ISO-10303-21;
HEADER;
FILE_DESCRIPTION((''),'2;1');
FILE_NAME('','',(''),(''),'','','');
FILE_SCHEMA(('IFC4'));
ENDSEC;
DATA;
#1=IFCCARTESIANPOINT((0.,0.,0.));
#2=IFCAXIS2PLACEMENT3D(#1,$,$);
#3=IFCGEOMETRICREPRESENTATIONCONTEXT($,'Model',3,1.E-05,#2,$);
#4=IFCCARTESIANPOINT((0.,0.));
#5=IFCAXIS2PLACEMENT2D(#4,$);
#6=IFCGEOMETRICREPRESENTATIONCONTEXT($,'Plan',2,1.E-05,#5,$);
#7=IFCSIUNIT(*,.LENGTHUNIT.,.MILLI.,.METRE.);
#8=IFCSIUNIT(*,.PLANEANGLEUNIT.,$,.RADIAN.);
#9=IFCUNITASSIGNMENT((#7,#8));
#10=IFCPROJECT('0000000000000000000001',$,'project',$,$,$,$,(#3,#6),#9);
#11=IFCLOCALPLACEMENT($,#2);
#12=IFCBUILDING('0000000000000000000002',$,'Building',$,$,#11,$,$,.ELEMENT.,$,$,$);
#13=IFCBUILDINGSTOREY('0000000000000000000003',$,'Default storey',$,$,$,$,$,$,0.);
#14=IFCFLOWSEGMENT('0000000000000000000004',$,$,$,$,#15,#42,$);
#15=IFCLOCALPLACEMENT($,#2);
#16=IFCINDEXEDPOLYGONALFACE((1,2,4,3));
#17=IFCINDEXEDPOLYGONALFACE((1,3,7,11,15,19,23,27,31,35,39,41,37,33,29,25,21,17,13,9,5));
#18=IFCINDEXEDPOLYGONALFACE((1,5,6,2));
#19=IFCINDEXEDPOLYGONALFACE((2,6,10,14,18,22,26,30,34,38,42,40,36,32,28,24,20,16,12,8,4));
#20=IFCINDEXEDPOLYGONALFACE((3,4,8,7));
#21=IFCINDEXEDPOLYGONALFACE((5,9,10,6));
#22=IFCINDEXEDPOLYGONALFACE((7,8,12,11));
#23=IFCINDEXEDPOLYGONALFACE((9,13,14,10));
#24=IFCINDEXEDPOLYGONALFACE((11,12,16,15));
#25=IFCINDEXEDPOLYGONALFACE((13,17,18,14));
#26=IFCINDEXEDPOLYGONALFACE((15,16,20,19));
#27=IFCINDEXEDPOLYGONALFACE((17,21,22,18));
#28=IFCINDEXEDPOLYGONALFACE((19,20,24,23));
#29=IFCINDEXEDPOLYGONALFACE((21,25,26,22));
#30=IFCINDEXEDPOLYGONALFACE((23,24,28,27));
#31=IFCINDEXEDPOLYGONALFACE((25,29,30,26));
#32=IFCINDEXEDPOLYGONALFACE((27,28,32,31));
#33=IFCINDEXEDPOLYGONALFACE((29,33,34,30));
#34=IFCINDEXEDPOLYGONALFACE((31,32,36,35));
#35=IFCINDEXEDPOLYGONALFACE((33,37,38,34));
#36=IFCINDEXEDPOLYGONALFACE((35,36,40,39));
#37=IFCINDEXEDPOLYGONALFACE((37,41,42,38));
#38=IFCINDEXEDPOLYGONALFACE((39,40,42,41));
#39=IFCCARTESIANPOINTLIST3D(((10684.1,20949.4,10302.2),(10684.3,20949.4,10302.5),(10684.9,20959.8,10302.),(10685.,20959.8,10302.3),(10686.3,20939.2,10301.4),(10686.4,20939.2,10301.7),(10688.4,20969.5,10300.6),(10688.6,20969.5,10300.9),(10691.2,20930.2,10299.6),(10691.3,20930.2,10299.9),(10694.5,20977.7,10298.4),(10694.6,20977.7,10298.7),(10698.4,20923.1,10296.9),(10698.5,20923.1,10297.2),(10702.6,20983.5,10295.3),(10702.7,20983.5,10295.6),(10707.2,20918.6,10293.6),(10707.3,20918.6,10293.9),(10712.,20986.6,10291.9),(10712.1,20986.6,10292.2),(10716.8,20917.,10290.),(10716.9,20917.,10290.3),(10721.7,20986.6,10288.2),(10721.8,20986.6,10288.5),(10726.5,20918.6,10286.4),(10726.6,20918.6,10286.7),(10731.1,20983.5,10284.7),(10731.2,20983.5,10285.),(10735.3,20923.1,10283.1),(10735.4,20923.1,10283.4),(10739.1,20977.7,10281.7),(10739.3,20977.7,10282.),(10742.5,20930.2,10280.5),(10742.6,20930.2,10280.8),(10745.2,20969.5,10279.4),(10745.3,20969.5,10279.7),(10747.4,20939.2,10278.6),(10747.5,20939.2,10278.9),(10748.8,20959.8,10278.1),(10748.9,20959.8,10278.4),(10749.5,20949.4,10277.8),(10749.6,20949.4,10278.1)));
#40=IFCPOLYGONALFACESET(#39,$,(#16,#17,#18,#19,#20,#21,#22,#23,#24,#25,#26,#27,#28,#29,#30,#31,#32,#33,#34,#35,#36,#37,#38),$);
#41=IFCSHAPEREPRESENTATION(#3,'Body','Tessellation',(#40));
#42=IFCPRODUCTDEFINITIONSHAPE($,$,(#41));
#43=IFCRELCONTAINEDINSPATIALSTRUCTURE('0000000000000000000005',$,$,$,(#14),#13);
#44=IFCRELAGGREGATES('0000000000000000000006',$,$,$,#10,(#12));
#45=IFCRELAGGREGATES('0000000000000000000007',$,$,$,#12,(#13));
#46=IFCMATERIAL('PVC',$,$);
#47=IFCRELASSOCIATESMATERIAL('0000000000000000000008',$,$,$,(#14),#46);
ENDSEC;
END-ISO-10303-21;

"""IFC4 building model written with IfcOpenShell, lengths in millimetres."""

from ifc_helpers import new_model, si_unit, frame, origin, origin_2d, place, context, project, spatial, circle, extrude, material, element, save


model = new_model("IFC4")

# Units and contexts
model_context = context("Model", 3, precision=1e-05, world=origin())
plan_context = context("Plan", 2, precision=1e-05, world=origin_2d())
ifc_project = project(units=[si_unit("LENGTHUNIT", "METRE", prefix="MILLI"), si_unit("PLANEANGLEUNIT", "RADIAN")], contexts=[model_context, plan_context])

# Building, storey
placement = place(None, origin())
building = spatial("IfcBuilding", under=ifc_project, at=placement, Name="Building", CompositionType="ELEMENT")
storey = spatial("IfcBuildingStorey", under=building, Name="Default storey", Elevation=0.0)

# Flow segment
ifc_material = material(Name="PVC")
element("IfcFlowSegment", 1, at=placement, inside=storey, material=ifc_material, context=model_context, shape_type="SweptSolid", body=[
    extrude(circle(Radius=35.0, at=origin_2d()), frame((10716.8, 20952.0, 10290.0), z_axis=(0.109495, 0.0, 0.29329), x_axis=(0.0, -109.494844, 0.0)), (0.0, 0.0, 1.0), 0.3),
])

save(model, "model.ifc")
